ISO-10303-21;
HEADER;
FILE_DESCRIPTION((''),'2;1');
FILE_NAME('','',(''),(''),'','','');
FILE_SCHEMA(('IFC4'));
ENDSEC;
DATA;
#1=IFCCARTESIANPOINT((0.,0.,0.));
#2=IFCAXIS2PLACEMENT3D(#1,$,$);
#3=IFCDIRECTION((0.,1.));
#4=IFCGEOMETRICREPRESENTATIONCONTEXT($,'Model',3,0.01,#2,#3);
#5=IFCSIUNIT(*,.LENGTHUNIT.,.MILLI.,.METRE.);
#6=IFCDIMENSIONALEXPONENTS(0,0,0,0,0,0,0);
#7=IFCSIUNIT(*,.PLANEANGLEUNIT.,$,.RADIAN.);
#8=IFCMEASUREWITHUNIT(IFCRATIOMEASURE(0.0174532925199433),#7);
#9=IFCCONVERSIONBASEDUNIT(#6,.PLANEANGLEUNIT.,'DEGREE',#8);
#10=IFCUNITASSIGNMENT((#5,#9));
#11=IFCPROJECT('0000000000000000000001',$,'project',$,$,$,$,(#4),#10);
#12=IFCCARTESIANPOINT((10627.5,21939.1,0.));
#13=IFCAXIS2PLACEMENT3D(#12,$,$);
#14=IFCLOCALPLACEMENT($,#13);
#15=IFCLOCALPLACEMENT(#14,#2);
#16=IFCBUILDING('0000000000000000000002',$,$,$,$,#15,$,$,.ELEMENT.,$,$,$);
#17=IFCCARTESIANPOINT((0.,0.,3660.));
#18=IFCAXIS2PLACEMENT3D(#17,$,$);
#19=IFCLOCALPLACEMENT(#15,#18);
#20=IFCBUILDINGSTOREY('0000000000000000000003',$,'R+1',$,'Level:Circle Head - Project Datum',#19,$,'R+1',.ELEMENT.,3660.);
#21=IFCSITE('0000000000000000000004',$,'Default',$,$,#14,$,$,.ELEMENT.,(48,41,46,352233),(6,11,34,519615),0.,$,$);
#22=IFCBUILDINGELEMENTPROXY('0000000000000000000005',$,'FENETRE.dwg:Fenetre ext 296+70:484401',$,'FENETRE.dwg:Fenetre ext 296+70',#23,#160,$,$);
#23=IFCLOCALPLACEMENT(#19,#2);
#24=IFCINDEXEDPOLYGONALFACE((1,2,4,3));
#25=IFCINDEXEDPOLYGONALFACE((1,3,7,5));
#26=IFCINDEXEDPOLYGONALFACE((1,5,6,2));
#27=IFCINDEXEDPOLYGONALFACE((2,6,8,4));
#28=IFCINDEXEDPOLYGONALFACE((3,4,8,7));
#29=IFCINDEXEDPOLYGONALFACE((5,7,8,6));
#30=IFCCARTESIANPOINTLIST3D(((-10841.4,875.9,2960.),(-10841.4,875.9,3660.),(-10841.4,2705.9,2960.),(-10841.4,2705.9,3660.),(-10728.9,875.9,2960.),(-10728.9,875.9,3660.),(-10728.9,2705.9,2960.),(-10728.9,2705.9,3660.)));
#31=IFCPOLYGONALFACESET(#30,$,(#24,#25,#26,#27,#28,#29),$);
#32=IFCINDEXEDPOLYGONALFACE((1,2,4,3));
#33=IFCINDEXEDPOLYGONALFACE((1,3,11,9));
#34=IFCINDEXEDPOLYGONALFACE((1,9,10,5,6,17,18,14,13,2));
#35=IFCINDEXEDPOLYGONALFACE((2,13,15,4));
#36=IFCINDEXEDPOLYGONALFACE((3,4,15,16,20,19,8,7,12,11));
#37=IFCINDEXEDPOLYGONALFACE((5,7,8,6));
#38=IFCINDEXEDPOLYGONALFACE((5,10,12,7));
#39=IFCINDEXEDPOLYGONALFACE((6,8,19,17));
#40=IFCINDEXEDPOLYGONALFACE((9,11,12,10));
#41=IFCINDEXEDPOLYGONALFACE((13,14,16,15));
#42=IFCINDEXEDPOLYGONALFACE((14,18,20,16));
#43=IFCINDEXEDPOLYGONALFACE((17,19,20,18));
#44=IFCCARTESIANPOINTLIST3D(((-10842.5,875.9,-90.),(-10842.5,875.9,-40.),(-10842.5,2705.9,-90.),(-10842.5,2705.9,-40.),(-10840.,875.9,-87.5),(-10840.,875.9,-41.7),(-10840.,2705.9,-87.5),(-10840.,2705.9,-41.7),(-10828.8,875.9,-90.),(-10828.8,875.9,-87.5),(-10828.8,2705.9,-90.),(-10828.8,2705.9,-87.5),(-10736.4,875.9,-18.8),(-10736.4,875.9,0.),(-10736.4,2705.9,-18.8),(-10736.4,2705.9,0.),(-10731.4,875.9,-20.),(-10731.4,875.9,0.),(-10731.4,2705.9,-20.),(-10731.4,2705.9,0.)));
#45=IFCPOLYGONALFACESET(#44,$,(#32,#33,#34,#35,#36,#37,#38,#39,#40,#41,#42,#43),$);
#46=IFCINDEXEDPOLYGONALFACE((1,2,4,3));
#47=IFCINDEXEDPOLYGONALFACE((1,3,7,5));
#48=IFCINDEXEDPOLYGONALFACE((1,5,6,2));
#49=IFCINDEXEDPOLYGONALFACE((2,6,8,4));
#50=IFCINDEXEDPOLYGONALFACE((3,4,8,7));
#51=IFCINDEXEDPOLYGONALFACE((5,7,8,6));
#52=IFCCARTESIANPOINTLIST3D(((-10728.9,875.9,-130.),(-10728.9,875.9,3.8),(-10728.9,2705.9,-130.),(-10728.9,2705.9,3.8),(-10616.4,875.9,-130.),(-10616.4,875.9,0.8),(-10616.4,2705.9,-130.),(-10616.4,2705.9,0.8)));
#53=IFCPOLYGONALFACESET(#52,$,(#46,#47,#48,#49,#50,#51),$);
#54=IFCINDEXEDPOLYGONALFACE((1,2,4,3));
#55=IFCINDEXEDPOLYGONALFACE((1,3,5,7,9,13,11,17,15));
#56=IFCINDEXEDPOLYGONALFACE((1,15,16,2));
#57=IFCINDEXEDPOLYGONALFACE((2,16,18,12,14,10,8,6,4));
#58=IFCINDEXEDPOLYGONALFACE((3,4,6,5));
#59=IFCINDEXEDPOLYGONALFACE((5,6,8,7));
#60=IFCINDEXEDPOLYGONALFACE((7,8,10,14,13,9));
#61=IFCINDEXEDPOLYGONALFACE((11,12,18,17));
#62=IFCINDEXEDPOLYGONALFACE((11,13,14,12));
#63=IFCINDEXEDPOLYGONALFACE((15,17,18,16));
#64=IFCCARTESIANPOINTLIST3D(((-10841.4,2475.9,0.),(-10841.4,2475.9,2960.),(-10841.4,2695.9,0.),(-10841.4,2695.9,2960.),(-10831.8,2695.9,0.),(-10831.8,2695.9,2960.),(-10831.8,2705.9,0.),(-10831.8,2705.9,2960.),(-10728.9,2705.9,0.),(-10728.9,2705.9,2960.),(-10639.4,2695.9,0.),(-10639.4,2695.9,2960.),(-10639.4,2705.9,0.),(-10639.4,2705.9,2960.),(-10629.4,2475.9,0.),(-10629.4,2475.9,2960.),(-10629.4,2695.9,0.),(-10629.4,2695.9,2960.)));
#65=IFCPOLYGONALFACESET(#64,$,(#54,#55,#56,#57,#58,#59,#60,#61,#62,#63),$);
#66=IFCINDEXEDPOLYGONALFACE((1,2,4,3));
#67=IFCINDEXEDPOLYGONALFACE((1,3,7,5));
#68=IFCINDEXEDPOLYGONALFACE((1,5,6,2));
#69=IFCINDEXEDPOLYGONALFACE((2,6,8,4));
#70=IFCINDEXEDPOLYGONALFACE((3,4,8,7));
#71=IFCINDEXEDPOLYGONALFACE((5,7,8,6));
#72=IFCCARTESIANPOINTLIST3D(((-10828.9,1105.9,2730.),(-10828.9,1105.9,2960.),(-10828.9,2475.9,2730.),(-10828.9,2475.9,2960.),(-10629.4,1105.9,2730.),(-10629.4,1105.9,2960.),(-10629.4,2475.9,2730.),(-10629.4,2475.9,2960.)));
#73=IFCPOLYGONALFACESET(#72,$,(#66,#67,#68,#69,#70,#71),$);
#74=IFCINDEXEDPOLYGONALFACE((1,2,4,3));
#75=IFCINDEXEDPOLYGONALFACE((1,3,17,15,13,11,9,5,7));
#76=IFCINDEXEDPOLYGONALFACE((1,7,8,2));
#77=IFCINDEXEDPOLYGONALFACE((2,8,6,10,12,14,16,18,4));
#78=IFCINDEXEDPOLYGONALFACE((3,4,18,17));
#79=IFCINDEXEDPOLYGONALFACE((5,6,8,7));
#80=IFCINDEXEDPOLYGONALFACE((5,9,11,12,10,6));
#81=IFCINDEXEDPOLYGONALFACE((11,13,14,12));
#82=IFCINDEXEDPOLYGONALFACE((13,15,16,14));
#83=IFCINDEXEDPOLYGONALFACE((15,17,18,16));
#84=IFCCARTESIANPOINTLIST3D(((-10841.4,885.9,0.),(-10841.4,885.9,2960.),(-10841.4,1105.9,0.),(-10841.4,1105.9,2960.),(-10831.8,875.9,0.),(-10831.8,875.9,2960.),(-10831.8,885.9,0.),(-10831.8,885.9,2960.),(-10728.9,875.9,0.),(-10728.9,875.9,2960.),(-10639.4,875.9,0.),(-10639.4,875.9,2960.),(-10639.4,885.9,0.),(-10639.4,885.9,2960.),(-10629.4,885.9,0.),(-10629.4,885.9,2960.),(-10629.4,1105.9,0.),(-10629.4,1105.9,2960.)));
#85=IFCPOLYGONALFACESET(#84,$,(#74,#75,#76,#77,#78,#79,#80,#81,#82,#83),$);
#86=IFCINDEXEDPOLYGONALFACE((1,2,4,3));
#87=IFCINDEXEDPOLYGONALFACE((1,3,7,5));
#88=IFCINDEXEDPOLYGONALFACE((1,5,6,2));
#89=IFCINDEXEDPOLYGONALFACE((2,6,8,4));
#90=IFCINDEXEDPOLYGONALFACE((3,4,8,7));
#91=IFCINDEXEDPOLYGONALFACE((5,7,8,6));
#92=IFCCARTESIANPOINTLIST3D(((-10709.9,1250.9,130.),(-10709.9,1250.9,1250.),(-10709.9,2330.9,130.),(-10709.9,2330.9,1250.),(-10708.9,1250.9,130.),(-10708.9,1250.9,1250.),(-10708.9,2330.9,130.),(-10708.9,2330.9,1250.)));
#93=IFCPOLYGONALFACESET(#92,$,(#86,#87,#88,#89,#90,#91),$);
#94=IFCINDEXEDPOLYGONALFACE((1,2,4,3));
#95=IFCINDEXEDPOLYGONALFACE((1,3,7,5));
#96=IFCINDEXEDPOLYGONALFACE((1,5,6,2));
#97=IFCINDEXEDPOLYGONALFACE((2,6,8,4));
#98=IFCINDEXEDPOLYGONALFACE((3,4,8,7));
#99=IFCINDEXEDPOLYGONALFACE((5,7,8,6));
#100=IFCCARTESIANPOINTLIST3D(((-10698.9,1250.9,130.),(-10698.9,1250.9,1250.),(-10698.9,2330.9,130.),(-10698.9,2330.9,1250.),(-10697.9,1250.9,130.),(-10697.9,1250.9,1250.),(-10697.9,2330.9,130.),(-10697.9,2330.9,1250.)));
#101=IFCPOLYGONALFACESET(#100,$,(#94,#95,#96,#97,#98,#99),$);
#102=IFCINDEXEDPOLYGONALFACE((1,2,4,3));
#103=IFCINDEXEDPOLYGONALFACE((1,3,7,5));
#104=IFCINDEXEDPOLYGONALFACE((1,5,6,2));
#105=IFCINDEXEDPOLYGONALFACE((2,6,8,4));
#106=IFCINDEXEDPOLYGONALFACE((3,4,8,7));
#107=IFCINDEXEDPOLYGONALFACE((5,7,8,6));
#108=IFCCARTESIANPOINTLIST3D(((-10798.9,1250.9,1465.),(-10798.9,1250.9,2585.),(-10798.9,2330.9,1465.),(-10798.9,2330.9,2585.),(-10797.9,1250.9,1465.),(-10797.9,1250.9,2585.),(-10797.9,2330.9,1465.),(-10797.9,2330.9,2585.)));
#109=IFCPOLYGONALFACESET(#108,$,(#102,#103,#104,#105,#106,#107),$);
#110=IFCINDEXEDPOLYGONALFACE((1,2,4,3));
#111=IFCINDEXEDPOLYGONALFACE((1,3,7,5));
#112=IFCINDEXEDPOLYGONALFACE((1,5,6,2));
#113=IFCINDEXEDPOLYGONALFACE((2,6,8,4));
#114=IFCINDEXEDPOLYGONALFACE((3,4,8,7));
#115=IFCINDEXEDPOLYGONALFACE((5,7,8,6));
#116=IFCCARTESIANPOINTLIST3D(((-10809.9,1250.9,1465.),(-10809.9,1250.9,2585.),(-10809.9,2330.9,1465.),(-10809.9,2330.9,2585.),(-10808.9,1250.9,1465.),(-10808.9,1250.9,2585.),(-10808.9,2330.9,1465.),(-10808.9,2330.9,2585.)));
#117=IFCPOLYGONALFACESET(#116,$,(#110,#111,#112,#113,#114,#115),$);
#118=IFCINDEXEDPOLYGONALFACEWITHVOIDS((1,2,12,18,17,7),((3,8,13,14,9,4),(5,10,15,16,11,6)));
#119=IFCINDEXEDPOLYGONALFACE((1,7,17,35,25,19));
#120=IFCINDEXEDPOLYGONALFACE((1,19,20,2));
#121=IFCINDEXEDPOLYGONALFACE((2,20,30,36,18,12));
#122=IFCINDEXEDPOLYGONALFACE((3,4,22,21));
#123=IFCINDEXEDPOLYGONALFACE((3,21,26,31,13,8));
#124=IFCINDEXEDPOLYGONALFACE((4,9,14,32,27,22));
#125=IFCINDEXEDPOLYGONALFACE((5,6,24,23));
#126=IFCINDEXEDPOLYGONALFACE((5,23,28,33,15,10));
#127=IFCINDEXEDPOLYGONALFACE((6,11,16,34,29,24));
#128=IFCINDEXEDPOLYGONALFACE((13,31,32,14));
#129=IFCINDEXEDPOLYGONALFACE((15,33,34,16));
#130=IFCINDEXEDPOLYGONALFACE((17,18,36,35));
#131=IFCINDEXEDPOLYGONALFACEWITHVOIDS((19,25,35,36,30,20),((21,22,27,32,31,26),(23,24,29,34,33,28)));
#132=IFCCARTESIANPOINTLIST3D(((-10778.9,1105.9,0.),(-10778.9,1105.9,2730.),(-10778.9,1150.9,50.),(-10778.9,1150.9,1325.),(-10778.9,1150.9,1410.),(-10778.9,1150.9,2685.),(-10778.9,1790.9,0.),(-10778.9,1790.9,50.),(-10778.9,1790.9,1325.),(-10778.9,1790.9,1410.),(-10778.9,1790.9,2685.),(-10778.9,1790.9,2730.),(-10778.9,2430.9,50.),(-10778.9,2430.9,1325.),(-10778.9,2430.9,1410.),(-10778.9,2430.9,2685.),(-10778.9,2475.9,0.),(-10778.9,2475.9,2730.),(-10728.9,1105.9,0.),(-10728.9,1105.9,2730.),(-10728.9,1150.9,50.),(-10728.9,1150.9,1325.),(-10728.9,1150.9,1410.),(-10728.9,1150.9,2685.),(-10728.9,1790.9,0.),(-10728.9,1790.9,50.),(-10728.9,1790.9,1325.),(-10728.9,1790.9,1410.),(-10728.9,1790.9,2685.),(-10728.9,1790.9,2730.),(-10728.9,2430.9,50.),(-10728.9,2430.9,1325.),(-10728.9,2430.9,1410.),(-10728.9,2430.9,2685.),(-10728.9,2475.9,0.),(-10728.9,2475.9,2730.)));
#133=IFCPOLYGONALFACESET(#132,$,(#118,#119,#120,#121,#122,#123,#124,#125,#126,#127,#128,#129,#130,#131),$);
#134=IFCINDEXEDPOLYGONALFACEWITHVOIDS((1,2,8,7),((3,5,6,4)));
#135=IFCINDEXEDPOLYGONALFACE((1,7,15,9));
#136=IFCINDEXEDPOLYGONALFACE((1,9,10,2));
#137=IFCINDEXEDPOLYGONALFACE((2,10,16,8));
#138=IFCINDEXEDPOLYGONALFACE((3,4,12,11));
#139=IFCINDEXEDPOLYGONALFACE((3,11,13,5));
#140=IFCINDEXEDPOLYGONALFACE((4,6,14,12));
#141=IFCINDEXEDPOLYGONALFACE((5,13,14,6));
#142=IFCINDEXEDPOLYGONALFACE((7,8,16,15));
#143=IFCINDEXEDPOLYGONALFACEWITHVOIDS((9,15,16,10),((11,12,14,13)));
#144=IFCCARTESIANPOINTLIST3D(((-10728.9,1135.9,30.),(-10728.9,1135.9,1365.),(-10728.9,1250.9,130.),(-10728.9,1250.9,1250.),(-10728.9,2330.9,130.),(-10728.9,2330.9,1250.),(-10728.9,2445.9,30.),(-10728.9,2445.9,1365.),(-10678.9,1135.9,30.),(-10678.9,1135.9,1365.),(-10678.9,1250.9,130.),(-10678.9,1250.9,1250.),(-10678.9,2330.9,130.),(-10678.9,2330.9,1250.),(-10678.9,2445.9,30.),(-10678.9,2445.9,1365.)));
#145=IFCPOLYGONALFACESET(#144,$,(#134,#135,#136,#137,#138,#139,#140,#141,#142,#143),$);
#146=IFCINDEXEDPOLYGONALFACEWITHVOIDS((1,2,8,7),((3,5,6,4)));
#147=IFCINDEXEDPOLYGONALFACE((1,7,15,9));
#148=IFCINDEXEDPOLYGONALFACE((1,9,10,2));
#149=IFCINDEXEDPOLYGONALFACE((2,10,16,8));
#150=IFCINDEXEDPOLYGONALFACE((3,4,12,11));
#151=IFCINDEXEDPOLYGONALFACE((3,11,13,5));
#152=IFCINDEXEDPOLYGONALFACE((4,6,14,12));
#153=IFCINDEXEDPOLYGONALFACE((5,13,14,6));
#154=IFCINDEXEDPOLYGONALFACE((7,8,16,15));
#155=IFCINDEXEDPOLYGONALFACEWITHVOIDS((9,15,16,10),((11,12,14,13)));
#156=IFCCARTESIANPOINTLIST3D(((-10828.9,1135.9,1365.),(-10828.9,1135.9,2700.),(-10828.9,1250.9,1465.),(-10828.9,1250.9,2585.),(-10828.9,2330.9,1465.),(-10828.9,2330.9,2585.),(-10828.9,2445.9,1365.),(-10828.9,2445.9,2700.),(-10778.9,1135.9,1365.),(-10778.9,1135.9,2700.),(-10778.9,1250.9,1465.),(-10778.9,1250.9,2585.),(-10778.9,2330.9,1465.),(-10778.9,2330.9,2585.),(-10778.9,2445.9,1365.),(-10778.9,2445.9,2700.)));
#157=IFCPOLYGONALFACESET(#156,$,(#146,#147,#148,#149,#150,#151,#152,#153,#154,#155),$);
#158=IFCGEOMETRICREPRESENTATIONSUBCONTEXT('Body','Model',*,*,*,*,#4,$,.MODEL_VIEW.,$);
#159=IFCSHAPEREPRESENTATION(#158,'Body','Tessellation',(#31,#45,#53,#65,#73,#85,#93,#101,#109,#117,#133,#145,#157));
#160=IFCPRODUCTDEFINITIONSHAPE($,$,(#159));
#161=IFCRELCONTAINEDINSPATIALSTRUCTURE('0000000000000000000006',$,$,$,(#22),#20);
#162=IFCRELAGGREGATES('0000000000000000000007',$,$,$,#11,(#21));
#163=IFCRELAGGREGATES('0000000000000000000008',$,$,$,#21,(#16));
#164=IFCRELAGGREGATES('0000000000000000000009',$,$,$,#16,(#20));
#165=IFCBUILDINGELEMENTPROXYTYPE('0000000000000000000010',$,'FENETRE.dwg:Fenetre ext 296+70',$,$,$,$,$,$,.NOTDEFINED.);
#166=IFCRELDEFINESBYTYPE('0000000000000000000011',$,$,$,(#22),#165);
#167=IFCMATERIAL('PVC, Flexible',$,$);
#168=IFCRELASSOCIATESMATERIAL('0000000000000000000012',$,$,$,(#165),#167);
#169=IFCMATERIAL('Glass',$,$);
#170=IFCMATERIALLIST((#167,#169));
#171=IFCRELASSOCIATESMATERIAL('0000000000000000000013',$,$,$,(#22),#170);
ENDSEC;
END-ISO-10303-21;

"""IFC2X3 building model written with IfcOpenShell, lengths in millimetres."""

from ifc_helpers import new_model, entity, si_unit, converted_unit, direction, frame, frame_2d, origin, origin_2d_with_axis, place, context, subcontext, project, spatial, polyline, rectangle, outline, extrude, source, transform, mapped, material, material_list, type_object, type_shapes, element, save


model = new_model("IFC2X3")

# Units and contexts
model_context = context("Model", 3, precision=0.01, world=origin(), true_north=direction((0.0, 1.0)))
body_context = subcontext(model_context, "Body", "Model", "MODEL_VIEW")
ifc_project = project(units=[si_unit("LENGTHUNIT", "METRE", prefix="MILLI"), converted_unit("PLANEANGLEUNIT", "DEGREE", entity("IfcRatioMeasure", 0.0174532925199433), si_unit("PLANEANGLEUNIT", "RADIAN"), dimensions=[0, 0, 0, 0, 0, 0, 0])], contexts=[model_context])

# Site, building, storey
site_placement = place(None, frame((10627.5, 21939.1, 0.0)))
site = spatial("IfcSite", under=ifc_project, at=site_placement, Name="Default", CompositionType="ELEMENT", RefLatitude=(48, 41, 46, 352233), RefLongitude=(6, 11, 34, 519615), RefElevation=0.0)
building_placement = place(site_placement, origin())
building = spatial("IfcBuilding", under=site, at=building_placement, CompositionType="ELEMENT")
storey_placement = place(building_placement, frame((0.0, 0.0, 3660.0)))
storey = spatial("IfcBuildingStorey", under=building, at=storey_placement, Name="R+1", ObjectType="Level:Circle Head - Project Datum", LongName="R+1", CompositionType="ELEMENT", Elevation=3660.0)

# Building element proxy
ifc_material_1 = material(Name="PVC, Flexible")
ifc_material_2 = material(Name="Glass")
building_element_proxy_type_1 = type_object("IfcBuildingElementProxyType", Name="FENETRE.dwg:Fenetre ext 296+70", PredefinedType="NOTDEFINED", material=ifc_material_1)
shared_shape_1 = source(origin(), body_context, "Body", "SweptSolid", [
    extrude(rectangle(XDim=1830.0, YDim=112.5, at=origin_2d_with_axis()), frame((-10.4, 56.3, 2960.0), z_axis=(0.0, 0.0, 1.0), x_axis=(-1.0, 0.0, 0.0)), (0.0, 0.0, 1.0), 700.0),
    extrude(outline(polyline([(-68.6, -14.4), (-72.5, -34.0), (-67.6, -35.0), (-63.9, -16.6), (44.3, -16.6), (54.1, 32.5), (40.6, 35.2), (40.1, 32.7), (51.2, 30.5), (42.2, -14.4), (-68.6, -14.4)])), frame((-925.4, 66.9, -47.5), z_axis=(-1.0, 0.0, 0.0), x_axis=(0.0, 0.980599, -0.196027)), (0.0, 0.0, -1.0), 1830.0),
    extrude(outline(polyline([(-64.7, -56.3), (66.2, -56.3), (66.2, 56.3), (-67.7, 56.3), (-64.7, -56.3)])), frame((-925.4, -56.3, -63.8), z_axis=(1.0, 0.0, 0.0), x_axis=(0.0, 0.0, -1.0)), (0.0, 0.0, 1.0), 1830.0),
    extrude(outline(polyline([(-55.6, 97.0), (-55.6, -5.9), (-55.6, -95.4), (-45.6, -95.4), (-45.6, -105.4), (174.4, -105.4), (174.4, 106.6), (-45.6, 106.6), (-45.6, 97.0), (-55.6, 97.0)])), frame((849.0, 5.9, 0.0), z_axis=(0.0, 0.0, -1.0), x_axis=(-1.0, 0.0, 0.0)), (0.0, 0.0, -1.0), 2960.0),
    extrude(rectangle(XDim=199.5, YDim=1370.0, at=origin_2d_with_axis()), frame((-10.4, 0.3, 2730.0), z_axis=(0.0, 0.0, 1.0), x_axis=(0.0, 1.0, 0.0)), (0.0, 0.0, 1.0), 230.0),
    extrude(outline(polyline([(-97.0, -55.6), (5.9, -55.6), (95.4, -55.6), (95.4, -45.6), (105.4, -45.6), (105.4, 174.4), (-106.6, 174.4), (-106.6, -45.6), (-97.0, -45.6), (-97.0, -55.6)])), frame((-869.9, 5.9, 0.0), z_axis=(0.0, 0.0, 1.0), x_axis=(0.0, -1.0, 0.0)), (0.0, 0.0, 1.0), 2960.0),
    extrude(rectangle(XDim=1.0, YDim=1080.0, at=origin_2d_with_axis()), frame((-10.4, -19.5, 130.0), z_axis=(0.0, 0.0, 1.0), x_axis=(0.0, 1.0, 0.0)), (0.0, 0.0, 1.0), 1120.0),
    extrude(rectangle(XDim=1.0, YDim=1080.0, at=frame_2d((0.0, 0.0), x_axis=(1.0, 0.0))), frame((-10.4, -30.5, 130.0), z_axis=(0.0, 0.0, 1.0), x_axis=(0.0, 1.0, 0.0)), (0.0, 0.0, 1.0), 1120.0),
    extrude(rectangle(XDim=1.0, YDim=1080.0, at=frame_2d((0.0, 0.0), x_axis=(1.0, 0.0))), frame((-10.4, 69.5, 1465.0), z_axis=(0.0, 0.0, 1.0), x_axis=(0.0, 1.0, 0.0)), (0.0, 0.0, 1.0), 1120.0),
    extrude(rectangle(XDim=1.0, YDim=1080.0, at=frame_2d((0.0, 0.0), x_axis=(1.0, 0.0))), frame((-10.4, 80.5, 1465.0), z_axis=(0.0, 0.0, 1.0), x_axis=(0.0, 1.0, 0.0)), (0.0, 0.0, 1.0), 1120.0),
    extrude(outline(polyline([(-685.0, -1365.0), (0.0, -1365.0), (685.0, -1365.0), (685.0, 1365.0), (0.0, 1365.0), (-685.0, 1365.0), (-685.0, -1365.0)]), holes=[polyline([(-640.0, -1320.0), (-640.0, -45.0), (0.0, -45.0), (640.0, -45.0), (640.0, -1320.0), (0.0, -1320.0), (-640.0, -1320.0)]), polyline([(-640.0, 40.0), (-640.0, 1315.0), (0.0, 1315.0), (640.0, 1315.0), (640.0, 40.0), (0.0, 40.0), (-640.0, 40.0)])]), frame((-10.4, 0.0, 1365.0), z_axis=(0.0, 1.0, 0.0), x_axis=(1.0, 0.0, 0.0)), (0.0, 0.0, 1.0), 50.0),
    extrude(outline(polyline([(-655.0, -667.5), (655.0, -667.5), (655.0, 667.5), (-655.0, 667.5), (-655.0, -667.5)]), holes=[polyline([(-540.0, 552.5), (540.0, 552.5), (540.0, -567.5), (-540.0, -567.5), (-540.0, 552.5)])]), frame((-10.4, -50.0, 697.5), z_axis=(0.0, 1.0, 0.0), x_axis=(-1.0, 0.0, 0.0)), (0.0, 0.0, 1.0), 50.0),
    extrude(outline(polyline([(-655.0, -667.5), (655.0, -667.5), (655.0, 667.5), (-655.0, 667.5), (-655.0, -667.5)]), holes=[polyline([(-540.0, 552.5), (540.0, 552.5), (540.0, -567.5), (-540.0, -567.5), (-540.0, 552.5)])]), frame((-10.4, 50.0, 2032.5), z_axis=(0.0, 1.0, 0.0), x_axis=(-1.0, 0.0, 0.0)), (0.0, 0.0, 1.0), 50.0),
])
type_shapes(building_element_proxy_type_1, [shared_shape_1])
ifc_material_list_1 = material_list([ifc_material_1, ifc_material_2])
proxy_1_placement = place(storey_placement, frame((-10728.9, 1801.3, 0.0), z_axis=(0.0, 0.0, 1.0), x_axis=(0.0, 1.0, 0.0)))
element("IfcBuildingElementProxy", 1, at=proxy_1_placement, inside=storey, type_object=building_element_proxy_type_1, material=ifc_material_list_1, Name="FENETRE.dwg:Fenetre ext 296+70:484401", ObjectType="FENETRE.dwg:Fenetre ext 296+70", context=body_context, shape_type="MappedRepresentation", body=[
    mapped(shared_shape_1, transform((0.0, 0.0, 0.0), scale=1.0)),
])

save(model, "model.ifc")
